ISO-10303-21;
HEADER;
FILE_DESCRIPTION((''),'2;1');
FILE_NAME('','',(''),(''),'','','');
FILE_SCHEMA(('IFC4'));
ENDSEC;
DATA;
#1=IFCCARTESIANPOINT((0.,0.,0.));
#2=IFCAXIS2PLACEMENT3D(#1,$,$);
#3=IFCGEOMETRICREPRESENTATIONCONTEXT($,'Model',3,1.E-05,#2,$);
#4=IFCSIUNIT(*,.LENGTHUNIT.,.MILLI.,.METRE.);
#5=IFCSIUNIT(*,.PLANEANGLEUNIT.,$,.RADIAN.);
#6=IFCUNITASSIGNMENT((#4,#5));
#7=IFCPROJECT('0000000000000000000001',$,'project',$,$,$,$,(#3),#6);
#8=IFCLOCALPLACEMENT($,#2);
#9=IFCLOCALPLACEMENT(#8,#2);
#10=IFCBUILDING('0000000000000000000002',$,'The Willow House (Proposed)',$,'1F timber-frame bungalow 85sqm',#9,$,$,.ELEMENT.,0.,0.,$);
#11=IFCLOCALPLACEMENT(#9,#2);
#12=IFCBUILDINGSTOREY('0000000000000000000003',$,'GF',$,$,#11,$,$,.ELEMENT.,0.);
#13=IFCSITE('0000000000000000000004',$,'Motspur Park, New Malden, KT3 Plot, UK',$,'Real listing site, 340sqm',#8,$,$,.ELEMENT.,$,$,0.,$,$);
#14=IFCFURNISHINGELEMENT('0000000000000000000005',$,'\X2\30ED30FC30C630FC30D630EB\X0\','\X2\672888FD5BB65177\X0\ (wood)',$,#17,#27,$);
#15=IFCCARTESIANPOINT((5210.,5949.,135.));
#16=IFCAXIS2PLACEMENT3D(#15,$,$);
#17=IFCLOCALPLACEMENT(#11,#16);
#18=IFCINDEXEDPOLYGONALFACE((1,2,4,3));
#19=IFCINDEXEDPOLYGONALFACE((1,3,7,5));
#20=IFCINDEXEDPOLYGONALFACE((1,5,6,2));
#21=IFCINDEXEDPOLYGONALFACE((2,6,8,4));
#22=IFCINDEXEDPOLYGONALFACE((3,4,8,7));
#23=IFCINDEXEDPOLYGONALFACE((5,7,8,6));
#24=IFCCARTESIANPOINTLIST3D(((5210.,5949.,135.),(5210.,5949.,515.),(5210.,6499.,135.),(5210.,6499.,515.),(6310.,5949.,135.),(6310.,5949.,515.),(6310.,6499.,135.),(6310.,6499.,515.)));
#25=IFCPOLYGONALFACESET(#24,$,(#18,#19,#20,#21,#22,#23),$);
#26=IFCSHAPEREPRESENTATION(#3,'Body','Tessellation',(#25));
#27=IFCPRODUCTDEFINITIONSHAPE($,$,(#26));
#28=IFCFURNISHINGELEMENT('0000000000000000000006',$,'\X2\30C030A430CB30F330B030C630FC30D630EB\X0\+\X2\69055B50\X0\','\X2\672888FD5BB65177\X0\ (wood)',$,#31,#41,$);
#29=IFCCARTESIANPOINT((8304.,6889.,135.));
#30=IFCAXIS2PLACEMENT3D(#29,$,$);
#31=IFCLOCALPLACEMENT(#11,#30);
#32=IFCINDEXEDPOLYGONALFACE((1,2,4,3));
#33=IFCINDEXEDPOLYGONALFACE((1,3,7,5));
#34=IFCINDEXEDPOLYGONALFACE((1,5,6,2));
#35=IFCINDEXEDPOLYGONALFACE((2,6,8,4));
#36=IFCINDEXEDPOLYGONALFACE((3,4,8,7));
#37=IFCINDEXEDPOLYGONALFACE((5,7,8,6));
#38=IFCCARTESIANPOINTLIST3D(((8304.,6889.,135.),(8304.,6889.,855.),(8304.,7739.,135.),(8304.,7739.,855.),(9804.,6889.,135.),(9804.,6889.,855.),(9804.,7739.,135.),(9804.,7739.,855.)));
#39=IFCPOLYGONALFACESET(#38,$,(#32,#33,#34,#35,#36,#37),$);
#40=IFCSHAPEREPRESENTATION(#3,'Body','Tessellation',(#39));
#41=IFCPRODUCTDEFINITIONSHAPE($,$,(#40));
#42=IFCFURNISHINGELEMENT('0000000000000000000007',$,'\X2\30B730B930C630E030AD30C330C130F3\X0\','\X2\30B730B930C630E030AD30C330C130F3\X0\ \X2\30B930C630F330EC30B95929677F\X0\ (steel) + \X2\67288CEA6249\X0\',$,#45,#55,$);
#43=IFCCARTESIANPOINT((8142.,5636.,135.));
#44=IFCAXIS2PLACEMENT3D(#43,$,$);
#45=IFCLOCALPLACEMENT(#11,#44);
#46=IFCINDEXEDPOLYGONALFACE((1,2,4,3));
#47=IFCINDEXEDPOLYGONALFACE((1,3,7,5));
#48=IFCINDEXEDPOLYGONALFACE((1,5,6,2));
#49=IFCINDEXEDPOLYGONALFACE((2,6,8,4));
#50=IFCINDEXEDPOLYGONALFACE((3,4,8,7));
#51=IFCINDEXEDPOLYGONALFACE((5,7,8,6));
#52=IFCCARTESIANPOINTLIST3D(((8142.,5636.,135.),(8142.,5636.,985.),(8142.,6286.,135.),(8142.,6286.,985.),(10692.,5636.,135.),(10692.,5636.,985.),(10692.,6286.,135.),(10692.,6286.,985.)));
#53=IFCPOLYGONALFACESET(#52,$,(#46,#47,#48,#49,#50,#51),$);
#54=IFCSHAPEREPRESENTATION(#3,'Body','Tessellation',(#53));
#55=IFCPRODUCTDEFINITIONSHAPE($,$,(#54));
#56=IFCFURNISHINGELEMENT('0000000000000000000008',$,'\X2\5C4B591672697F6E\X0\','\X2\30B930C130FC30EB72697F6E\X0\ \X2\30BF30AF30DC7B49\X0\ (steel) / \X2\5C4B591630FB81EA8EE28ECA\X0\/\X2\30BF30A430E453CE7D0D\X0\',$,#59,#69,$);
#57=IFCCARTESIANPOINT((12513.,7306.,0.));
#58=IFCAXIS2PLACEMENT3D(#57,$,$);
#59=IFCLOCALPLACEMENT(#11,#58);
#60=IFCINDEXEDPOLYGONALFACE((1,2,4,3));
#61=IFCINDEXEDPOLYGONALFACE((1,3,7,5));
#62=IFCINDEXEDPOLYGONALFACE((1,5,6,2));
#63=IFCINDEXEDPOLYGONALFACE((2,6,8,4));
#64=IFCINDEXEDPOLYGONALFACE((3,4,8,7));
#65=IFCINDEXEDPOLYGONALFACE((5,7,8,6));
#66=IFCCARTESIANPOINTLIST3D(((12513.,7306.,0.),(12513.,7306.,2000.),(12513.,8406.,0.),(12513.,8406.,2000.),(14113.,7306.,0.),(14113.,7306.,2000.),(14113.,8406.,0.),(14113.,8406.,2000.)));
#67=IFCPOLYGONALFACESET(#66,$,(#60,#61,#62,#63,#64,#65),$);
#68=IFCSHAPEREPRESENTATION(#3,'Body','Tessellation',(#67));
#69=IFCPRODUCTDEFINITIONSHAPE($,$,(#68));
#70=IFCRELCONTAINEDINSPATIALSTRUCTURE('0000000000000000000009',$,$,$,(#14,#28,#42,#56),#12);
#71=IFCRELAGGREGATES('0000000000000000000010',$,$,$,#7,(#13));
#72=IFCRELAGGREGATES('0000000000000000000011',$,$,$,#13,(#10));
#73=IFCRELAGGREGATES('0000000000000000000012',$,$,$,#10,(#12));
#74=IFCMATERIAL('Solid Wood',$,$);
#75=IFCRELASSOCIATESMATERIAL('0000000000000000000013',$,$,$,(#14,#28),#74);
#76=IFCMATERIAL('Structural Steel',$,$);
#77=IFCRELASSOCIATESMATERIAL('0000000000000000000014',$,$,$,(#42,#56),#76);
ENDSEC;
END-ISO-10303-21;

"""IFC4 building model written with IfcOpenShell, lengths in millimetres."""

from ifc_helpers import new_model, si_unit, frame, frame_2d, origin, place, context, project, spatial, rectangle, extrude, material, element, save


model = new_model("IFC4")

# Units and contexts
model_context = context("Model", 3, precision=1e-05, world=origin())
ifc_project = project(units=[si_unit("LENGTHUNIT", "METRE", prefix="MILLI"), si_unit("PLANEANGLEUNIT", "RADIAN")], contexts=[model_context])

# Site, building, storey
site_placement = place(None, origin())
site = spatial("IfcSite", under=ifc_project, at=site_placement, Name="Motspur Park, New Malden, KT3 Plot, UK", ObjectType="Real listing site, 340sqm", CompositionType="ELEMENT", RefElevation=0.0)
building_placement = place(site_placement, origin())
building = spatial("IfcBuilding", under=site, at=building_placement, Name="The Willow House (Proposed)", ObjectType="1F timber-frame bungalow 85sqm", CompositionType="ELEMENT", ElevationOfRefHeight=0.0, ElevationOfTerrain=0.0)
storey_placement = place(building_placement, origin())
storey = spatial("IfcBuildingStorey", under=building, at=storey_placement, Name="GF", CompositionType="ELEMENT", Elevation=0.0)

# Shared definitions
ifc_material_1 = material(Name="Solid Wood")

# Shared definitions
ifc_material_2 = material(Name="Structural Steel")

# Furnishing elements
furnishing_1_placement = place(storey_placement, frame((5210.0, 5949.0, 135.0)))
element("IfcFurnishingElement", 1, at=furnishing_1_placement, inside=storey, material=ifc_material_1, Name="ローテーブル", Description="木製家具 (wood)", context=model_context, shape_type="SweptSolid", body=[
    extrude(rectangle(XDim=1100.0, YDim=550.0, at=frame_2d((550.0, 275.0))), frame((5210.0, 5949.0, 135.0)), (0.0, 0.0, 1.0), 380.0),
])
furnishing_2_placement = place(storey_placement, frame((8304.0, 6889.0, 135.0)))
element("IfcFurnishingElement", 2, at=furnishing_2_placement, inside=storey, material=ifc_material_1, Name="ダイニングテーブル+椅子", Description="木製家具 (wood)", context=model_context, shape_type="SweptSolid", body=[
    extrude(rectangle(XDim=1500.0, YDim=850.0, at=frame_2d((750.0, 425.0))), frame((8304.0, 6889.0, 135.0)), (0.0, 0.0, 1.0), 720.0),
])
furnishing_3_placement = place(storey_placement, frame((8142.0, 5636.0, 135.0)))
element("IfcFurnishingElement", 3, at=furnishing_3_placement, inside=storey, material=ifc_material_2, Name="システムキッチン", Description="システムキッチン ステンレス天板 (steel) + 木質扉", context=model_context, shape_type="SweptSolid", body=[
    extrude(rectangle(XDim=2550.0, YDim=650.0, at=frame_2d((1275.0, 325.0))), frame((8142.0, 5636.0, 135.0)), (0.0, 0.0, 1.0), 850.0),
])
furnishing_4_placement = place(storey_placement, frame((12513.0, 7306.0, 0.0)))
element("IfcFurnishingElement", 4, at=furnishing_4_placement, inside=storey, material=ifc_material_2, Name="屋外物置", Description="スチール物置 タクボ等 (steel) / 屋外・自転車/タイヤ収納", context=model_context, shape_type="SweptSolid", body=[
    extrude(rectangle(XDim=1600.0, YDim=1100.0, at=frame_2d((800.0, 550.0))), frame((12513.0, 7306.0, 0.0)), (0.0, 0.0, 1.0), 2000.0),
])

save(model, "model.ifc")
